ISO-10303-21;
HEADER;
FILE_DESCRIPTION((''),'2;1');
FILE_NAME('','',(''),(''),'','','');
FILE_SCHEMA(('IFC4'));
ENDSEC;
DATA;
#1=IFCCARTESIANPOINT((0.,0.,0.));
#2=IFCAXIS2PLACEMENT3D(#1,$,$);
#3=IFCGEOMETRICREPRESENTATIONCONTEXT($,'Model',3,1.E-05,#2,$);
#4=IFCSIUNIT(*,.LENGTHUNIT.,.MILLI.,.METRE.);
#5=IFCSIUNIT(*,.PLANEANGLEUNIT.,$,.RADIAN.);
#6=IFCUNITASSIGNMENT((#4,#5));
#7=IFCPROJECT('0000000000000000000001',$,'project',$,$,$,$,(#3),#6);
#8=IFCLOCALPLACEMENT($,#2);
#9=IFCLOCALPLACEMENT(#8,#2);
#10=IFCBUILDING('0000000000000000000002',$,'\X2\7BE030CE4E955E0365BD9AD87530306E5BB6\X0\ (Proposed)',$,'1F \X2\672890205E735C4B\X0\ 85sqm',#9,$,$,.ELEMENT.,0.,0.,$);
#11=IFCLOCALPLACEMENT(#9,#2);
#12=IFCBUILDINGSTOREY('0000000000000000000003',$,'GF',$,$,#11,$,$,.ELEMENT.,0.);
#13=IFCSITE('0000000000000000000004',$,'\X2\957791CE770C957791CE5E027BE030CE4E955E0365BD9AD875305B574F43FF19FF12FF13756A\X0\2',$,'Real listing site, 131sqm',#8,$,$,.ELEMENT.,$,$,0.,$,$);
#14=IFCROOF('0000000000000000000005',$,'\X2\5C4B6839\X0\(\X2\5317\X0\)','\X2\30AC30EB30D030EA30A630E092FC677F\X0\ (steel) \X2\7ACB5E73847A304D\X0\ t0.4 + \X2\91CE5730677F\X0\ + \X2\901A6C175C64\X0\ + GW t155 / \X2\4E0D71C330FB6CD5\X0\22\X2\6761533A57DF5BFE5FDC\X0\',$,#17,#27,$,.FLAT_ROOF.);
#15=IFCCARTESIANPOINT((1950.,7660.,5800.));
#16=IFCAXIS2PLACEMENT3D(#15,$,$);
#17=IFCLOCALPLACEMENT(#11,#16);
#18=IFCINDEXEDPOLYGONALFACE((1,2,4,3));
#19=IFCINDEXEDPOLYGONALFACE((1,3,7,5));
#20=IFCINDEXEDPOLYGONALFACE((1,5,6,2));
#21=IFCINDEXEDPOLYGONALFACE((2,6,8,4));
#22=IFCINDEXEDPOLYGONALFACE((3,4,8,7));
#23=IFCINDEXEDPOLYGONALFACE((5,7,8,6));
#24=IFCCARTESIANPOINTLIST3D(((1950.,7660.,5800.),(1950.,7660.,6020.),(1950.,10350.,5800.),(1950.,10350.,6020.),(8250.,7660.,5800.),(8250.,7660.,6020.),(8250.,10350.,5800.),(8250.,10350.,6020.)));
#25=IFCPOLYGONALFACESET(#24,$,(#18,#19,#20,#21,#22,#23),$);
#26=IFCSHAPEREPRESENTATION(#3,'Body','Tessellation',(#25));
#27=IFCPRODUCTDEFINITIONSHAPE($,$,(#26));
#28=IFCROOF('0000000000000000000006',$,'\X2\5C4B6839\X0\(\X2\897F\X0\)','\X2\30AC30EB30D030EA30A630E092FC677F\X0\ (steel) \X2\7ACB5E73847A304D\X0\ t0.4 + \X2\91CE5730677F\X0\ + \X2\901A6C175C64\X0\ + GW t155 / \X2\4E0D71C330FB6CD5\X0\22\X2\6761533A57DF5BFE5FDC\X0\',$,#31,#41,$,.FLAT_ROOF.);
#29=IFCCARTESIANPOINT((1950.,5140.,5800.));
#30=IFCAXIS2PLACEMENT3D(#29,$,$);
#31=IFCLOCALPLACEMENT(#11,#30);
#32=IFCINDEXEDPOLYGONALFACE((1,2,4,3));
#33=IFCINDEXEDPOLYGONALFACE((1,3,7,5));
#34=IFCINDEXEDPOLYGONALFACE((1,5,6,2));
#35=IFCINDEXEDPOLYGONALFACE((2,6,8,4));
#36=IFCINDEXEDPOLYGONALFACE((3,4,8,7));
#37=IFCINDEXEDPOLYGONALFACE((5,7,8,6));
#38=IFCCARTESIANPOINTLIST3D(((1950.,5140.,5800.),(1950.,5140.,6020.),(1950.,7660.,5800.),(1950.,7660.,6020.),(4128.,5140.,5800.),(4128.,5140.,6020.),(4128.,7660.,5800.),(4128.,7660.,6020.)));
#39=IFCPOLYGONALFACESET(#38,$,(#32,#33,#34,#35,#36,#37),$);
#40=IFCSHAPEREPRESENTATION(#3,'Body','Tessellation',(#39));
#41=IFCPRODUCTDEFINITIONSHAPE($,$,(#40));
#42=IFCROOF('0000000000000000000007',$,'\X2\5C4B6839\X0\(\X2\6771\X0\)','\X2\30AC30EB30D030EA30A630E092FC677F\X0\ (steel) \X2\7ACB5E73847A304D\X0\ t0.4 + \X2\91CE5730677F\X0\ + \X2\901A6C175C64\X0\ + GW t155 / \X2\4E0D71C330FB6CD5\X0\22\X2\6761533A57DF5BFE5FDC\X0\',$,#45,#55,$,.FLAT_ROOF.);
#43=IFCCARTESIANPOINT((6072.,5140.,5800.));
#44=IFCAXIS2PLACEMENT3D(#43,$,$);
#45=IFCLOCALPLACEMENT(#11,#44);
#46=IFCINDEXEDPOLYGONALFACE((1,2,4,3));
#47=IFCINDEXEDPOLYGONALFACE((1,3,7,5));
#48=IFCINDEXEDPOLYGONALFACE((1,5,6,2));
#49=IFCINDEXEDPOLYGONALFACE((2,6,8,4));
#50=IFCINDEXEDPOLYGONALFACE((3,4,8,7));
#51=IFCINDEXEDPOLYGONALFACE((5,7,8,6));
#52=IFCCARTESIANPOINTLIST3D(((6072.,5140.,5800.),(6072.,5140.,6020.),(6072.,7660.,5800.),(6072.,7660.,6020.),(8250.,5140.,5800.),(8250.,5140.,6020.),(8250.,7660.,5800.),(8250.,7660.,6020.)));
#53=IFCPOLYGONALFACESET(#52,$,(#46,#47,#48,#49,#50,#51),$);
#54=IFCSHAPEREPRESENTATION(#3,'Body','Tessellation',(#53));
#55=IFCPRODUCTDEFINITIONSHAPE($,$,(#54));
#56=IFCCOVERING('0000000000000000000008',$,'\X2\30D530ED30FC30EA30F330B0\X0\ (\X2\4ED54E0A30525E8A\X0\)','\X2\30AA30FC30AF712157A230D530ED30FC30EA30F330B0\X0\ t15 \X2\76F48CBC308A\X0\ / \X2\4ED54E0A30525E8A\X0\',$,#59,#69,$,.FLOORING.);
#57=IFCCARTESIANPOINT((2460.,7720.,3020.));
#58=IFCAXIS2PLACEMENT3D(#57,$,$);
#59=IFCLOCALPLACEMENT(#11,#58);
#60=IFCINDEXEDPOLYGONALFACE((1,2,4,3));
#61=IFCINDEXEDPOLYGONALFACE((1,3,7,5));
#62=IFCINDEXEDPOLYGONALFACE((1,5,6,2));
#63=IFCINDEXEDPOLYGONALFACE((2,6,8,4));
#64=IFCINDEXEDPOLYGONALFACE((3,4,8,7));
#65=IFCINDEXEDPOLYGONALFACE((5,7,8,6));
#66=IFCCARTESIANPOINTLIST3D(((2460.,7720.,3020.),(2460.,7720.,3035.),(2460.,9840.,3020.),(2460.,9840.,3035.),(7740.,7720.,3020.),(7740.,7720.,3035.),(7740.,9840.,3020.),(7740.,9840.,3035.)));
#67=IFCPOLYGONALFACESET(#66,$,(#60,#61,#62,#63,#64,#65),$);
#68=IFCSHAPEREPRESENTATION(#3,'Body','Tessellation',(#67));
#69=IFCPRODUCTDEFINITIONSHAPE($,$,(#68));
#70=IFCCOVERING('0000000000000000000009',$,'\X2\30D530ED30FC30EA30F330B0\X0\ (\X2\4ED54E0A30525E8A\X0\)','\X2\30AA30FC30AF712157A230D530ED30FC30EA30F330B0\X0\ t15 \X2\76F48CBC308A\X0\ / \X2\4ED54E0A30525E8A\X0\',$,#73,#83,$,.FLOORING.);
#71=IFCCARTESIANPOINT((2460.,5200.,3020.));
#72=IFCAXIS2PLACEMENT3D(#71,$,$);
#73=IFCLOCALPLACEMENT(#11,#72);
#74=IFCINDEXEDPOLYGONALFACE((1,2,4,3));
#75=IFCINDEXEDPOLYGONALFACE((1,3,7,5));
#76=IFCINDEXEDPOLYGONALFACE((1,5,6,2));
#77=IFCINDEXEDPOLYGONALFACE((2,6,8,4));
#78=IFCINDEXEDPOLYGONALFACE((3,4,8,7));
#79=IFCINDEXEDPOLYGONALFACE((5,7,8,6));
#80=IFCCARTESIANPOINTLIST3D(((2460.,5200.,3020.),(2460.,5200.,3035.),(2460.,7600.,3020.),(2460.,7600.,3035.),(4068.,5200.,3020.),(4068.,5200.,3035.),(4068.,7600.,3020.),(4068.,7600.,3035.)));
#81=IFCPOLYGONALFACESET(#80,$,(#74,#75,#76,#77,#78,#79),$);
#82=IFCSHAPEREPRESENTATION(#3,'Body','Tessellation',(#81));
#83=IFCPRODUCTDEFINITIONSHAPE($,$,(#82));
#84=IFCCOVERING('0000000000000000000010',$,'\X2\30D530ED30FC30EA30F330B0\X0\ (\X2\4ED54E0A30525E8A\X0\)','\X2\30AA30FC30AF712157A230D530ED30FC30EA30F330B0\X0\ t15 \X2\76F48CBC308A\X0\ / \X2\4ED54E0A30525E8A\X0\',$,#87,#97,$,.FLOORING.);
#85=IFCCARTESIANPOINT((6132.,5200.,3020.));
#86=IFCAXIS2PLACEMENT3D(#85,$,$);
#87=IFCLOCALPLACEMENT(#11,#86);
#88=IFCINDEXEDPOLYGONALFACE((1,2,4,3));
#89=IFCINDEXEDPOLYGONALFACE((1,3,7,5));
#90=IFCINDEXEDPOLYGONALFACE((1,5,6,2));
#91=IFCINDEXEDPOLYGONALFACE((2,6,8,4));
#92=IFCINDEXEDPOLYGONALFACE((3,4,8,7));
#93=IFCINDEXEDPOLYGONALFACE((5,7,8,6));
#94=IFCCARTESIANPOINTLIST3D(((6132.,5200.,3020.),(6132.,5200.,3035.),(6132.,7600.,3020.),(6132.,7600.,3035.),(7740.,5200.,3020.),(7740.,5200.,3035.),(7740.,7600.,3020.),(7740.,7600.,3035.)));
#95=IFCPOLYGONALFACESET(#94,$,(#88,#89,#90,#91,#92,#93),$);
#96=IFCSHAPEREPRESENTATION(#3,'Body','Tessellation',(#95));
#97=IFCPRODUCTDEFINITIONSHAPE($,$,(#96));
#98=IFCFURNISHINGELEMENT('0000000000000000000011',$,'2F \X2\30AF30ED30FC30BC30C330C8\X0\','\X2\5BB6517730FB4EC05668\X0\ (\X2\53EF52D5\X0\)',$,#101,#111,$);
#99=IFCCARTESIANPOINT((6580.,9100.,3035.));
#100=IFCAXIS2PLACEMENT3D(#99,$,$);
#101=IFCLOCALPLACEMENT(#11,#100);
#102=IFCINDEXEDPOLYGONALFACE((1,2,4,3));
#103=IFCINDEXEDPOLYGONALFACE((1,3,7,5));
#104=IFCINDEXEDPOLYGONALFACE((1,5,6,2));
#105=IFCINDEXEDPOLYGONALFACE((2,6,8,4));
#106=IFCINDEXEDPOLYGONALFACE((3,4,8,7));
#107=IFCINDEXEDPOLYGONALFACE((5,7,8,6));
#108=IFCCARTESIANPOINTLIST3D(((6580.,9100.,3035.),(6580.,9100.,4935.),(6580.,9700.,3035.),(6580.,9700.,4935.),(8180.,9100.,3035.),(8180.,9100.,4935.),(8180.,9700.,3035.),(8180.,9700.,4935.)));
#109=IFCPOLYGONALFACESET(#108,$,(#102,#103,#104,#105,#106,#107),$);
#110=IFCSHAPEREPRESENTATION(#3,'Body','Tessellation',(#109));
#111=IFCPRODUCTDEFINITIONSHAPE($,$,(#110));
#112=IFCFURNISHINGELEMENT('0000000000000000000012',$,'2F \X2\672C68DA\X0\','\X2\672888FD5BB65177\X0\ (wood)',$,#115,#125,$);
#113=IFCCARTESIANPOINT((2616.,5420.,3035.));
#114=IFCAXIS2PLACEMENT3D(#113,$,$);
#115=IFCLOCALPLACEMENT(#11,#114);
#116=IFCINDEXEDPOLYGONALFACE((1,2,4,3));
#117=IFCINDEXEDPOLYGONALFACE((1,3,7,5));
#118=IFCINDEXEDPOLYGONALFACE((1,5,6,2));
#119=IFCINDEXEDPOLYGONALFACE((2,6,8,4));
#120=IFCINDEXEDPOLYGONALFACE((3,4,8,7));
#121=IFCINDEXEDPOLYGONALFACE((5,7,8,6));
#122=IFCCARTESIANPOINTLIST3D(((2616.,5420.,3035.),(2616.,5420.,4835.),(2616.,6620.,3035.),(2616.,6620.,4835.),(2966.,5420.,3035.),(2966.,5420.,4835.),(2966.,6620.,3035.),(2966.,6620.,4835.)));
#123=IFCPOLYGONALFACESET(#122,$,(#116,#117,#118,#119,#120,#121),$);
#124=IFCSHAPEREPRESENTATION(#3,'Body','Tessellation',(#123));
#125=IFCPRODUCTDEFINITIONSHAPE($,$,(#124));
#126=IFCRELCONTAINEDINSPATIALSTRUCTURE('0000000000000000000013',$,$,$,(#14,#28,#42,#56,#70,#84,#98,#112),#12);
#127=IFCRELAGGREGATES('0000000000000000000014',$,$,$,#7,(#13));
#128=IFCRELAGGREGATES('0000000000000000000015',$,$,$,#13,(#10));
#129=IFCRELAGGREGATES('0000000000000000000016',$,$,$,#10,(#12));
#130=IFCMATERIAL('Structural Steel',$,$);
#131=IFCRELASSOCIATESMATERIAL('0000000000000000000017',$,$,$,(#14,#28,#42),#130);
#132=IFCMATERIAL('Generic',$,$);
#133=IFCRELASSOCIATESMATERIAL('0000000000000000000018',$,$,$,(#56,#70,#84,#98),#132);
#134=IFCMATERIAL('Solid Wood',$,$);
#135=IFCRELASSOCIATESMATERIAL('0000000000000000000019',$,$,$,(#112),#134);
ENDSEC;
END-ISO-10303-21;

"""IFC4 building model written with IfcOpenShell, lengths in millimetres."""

from ifc_helpers import new_model, si_unit, frame, frame_2d, origin, place, context, project, spatial, rectangle, extrude, material, element, save


model = new_model("IFC4")

# Units and contexts
model_context = context("Model", 3, precision=1e-05, world=origin())
ifc_project = project(units=[si_unit("LENGTHUNIT", "METRE", prefix="MILLI"), si_unit("PLANEANGLEUNIT", "RADIAN")], contexts=[model_context])

# Site, building, storey
site_placement = place(None, origin())
site = spatial("IfcSite", under=ifc_project, at=site_placement, Name="長野県長野市篠ノ井布施高田字佃９２３番2", ObjectType="Real listing site, 131sqm", CompositionType="ELEMENT", RefElevation=0.0)
building_placement = place(site_placement, origin())
building = spatial("IfcBuilding", under=site, at=building_placement, Name="篠ノ井布施高田の家 (Proposed)", ObjectType="1F 木造平屋 85sqm", CompositionType="ELEMENT", ElevationOfRefHeight=0.0, ElevationOfTerrain=0.0)
storey_placement = place(building_placement, origin())
storey = spatial("IfcBuildingStorey", under=building, at=storey_placement, Name="GF", CompositionType="ELEMENT", Elevation=0.0)

# Shared definitions
ifc_material_1 = material(Name="Solid Wood")

# Shared definitions
ifc_material_2 = material(Name="Generic")

# Roofs
ifc_material_3 = material(Name="Structural Steel")
for number, where, name in (
    (1, (1950.0, 7660.0, 5800.0), "屋根(北)"),
):
    element("IfcRoof", number, at=place(storey_placement, frame(where)), inside=storey, material=ifc_material_3, Name=name, Description="ガルバリウム鋼板 (steel) 立平葺き t0.4 + 野地板 + 通気層 + GW t155 / 不燃・法22条区域対応", PredefinedType="FLAT_ROOF", context=model_context, shape_type="SweptSolid", body=[
        extrude(rectangle(XDim=6300.0, YDim=2690.0, at=frame_2d((3150.0, 1345.0))), frame((1950.0, 7660.0, 5800.0)), (0.0, 0.0, 1.0), 220.0),
    ])
roof_1_placement = place(storey_placement, frame((1950.0, 5140.0, 5800.0)))
element("IfcRoof", 2, at=roof_1_placement, inside=storey, material=ifc_material_3, Name="屋根(西)", Description="ガルバリウム鋼板 (steel) 立平葺き t0.4 + 野地板 + 通気層 + GW t155 / 不燃・法22条区域対応", PredefinedType="FLAT_ROOF", context=model_context, shape_type="SweptSolid", body=[
    extrude(rectangle(XDim=2178.0, YDim=2520.0, at=frame_2d((1089.0, 1260.0))), frame((1950.0, 5140.0, 5800.0)), (0.0, 0.0, 1.0), 220.0),
])
roof_2_placement = place(storey_placement, frame((6072.0, 5140.0, 5800.0)))
element("IfcRoof", 3, at=roof_2_placement, inside=storey, material=ifc_material_3, Name="屋根(東)", Description="ガルバリウム鋼板 (steel) 立平葺き t0.4 + 野地板 + 通気層 + GW t155 / 不燃・法22条区域対応", PredefinedType="FLAT_ROOF", context=model_context, shape_type="SweptSolid", body=[
    extrude(rectangle(XDim=2178.0, YDim=2520.0, at=frame_2d((1089.0, 1260.0))), frame((6072.0, 5140.0, 5800.0)), (0.0, 0.0, 1.0), 220.0),
])

# Coverings
covering_1_placement = place(storey_placement, frame((2460.0, 7720.0, 3020.0)))
element("IfcCovering", 4, at=covering_1_placement, inside=storey, material=ifc_material_2, Name="フローリング (仕上げ床)", Description="オーク無垢フローリング t15 直貼り / 仕上げ床", PredefinedType="FLOORING", context=model_context, shape_type="SweptSolid", body=[
    extrude(rectangle(XDim=5280.0, YDim=2120.0, at=frame_2d((2640.0, 1060.0))), frame((2460.0, 7720.0, 3020.0)), (0.0, 0.0, 1.0), 15.0),
])
covering_2_placement = place(storey_placement, frame((2460.0, 5200.0, 3020.0)))
element("IfcCovering", 5, at=covering_2_placement, inside=storey, material=ifc_material_2, Name="フローリング (仕上げ床)", Description="オーク無垢フローリング t15 直貼り / 仕上げ床", PredefinedType="FLOORING", context=model_context, shape_type="SweptSolid", body=[
    extrude(rectangle(XDim=1608.0, YDim=2400.0, at=frame_2d((804.0, 1200.0))), frame((2460.0, 5200.0, 3020.0)), (0.0, 0.0, 1.0), 15.0),
])
covering_3_placement = place(storey_placement, frame((6132.0, 5200.0, 3020.0)))
element("IfcCovering", 6, at=covering_3_placement, inside=storey, material=ifc_material_2, Name="フローリング (仕上げ床)", Description="オーク無垢フローリング t15 直貼り / 仕上げ床", PredefinedType="FLOORING", context=model_context, shape_type="SweptSolid", body=[
    extrude(rectangle(XDim=1608.0, YDim=2400.0, at=frame_2d((804.0, 1200.0))), frame((6132.0, 5200.0, 3020.0)), (0.0, 0.0, 1.0), 15.0),
])

# Furnishing elements
furnishing_1_placement = place(storey_placement, frame((6580.0, 9100.0, 3035.0)))
element("IfcFurnishingElement", 7, at=furnishing_1_placement, inside=storey, material=ifc_material_2, Name="2F クローゼット", Description="家具・什器 (可動)", context=model_context, shape_type="SweptSolid", body=[
    extrude(rectangle(XDim=1600.0, YDim=600.0, at=frame_2d((800.0, 300.0))), frame((6580.0, 9100.0, 3035.0)), (0.0, 0.0, 1.0), 1900.0),
])
furnishing_2_placement = place(storey_placement, frame((2616.0, 5420.0, 3035.0)))
element("IfcFurnishingElement", 8, at=furnishing_2_placement, inside=storey, material=ifc_material_1, Name="2F 本棚", Description="木製家具 (wood)", context=model_context, shape_type="SweptSolid", body=[
    extrude(rectangle(XDim=350.0, YDim=1200.0, at=frame_2d((175.0, 600.0))), frame((2616.0, 5420.0, 3035.0)), (0.0, 0.0, 1.0), 1800.0),
])

save(model, "model.ifc")
